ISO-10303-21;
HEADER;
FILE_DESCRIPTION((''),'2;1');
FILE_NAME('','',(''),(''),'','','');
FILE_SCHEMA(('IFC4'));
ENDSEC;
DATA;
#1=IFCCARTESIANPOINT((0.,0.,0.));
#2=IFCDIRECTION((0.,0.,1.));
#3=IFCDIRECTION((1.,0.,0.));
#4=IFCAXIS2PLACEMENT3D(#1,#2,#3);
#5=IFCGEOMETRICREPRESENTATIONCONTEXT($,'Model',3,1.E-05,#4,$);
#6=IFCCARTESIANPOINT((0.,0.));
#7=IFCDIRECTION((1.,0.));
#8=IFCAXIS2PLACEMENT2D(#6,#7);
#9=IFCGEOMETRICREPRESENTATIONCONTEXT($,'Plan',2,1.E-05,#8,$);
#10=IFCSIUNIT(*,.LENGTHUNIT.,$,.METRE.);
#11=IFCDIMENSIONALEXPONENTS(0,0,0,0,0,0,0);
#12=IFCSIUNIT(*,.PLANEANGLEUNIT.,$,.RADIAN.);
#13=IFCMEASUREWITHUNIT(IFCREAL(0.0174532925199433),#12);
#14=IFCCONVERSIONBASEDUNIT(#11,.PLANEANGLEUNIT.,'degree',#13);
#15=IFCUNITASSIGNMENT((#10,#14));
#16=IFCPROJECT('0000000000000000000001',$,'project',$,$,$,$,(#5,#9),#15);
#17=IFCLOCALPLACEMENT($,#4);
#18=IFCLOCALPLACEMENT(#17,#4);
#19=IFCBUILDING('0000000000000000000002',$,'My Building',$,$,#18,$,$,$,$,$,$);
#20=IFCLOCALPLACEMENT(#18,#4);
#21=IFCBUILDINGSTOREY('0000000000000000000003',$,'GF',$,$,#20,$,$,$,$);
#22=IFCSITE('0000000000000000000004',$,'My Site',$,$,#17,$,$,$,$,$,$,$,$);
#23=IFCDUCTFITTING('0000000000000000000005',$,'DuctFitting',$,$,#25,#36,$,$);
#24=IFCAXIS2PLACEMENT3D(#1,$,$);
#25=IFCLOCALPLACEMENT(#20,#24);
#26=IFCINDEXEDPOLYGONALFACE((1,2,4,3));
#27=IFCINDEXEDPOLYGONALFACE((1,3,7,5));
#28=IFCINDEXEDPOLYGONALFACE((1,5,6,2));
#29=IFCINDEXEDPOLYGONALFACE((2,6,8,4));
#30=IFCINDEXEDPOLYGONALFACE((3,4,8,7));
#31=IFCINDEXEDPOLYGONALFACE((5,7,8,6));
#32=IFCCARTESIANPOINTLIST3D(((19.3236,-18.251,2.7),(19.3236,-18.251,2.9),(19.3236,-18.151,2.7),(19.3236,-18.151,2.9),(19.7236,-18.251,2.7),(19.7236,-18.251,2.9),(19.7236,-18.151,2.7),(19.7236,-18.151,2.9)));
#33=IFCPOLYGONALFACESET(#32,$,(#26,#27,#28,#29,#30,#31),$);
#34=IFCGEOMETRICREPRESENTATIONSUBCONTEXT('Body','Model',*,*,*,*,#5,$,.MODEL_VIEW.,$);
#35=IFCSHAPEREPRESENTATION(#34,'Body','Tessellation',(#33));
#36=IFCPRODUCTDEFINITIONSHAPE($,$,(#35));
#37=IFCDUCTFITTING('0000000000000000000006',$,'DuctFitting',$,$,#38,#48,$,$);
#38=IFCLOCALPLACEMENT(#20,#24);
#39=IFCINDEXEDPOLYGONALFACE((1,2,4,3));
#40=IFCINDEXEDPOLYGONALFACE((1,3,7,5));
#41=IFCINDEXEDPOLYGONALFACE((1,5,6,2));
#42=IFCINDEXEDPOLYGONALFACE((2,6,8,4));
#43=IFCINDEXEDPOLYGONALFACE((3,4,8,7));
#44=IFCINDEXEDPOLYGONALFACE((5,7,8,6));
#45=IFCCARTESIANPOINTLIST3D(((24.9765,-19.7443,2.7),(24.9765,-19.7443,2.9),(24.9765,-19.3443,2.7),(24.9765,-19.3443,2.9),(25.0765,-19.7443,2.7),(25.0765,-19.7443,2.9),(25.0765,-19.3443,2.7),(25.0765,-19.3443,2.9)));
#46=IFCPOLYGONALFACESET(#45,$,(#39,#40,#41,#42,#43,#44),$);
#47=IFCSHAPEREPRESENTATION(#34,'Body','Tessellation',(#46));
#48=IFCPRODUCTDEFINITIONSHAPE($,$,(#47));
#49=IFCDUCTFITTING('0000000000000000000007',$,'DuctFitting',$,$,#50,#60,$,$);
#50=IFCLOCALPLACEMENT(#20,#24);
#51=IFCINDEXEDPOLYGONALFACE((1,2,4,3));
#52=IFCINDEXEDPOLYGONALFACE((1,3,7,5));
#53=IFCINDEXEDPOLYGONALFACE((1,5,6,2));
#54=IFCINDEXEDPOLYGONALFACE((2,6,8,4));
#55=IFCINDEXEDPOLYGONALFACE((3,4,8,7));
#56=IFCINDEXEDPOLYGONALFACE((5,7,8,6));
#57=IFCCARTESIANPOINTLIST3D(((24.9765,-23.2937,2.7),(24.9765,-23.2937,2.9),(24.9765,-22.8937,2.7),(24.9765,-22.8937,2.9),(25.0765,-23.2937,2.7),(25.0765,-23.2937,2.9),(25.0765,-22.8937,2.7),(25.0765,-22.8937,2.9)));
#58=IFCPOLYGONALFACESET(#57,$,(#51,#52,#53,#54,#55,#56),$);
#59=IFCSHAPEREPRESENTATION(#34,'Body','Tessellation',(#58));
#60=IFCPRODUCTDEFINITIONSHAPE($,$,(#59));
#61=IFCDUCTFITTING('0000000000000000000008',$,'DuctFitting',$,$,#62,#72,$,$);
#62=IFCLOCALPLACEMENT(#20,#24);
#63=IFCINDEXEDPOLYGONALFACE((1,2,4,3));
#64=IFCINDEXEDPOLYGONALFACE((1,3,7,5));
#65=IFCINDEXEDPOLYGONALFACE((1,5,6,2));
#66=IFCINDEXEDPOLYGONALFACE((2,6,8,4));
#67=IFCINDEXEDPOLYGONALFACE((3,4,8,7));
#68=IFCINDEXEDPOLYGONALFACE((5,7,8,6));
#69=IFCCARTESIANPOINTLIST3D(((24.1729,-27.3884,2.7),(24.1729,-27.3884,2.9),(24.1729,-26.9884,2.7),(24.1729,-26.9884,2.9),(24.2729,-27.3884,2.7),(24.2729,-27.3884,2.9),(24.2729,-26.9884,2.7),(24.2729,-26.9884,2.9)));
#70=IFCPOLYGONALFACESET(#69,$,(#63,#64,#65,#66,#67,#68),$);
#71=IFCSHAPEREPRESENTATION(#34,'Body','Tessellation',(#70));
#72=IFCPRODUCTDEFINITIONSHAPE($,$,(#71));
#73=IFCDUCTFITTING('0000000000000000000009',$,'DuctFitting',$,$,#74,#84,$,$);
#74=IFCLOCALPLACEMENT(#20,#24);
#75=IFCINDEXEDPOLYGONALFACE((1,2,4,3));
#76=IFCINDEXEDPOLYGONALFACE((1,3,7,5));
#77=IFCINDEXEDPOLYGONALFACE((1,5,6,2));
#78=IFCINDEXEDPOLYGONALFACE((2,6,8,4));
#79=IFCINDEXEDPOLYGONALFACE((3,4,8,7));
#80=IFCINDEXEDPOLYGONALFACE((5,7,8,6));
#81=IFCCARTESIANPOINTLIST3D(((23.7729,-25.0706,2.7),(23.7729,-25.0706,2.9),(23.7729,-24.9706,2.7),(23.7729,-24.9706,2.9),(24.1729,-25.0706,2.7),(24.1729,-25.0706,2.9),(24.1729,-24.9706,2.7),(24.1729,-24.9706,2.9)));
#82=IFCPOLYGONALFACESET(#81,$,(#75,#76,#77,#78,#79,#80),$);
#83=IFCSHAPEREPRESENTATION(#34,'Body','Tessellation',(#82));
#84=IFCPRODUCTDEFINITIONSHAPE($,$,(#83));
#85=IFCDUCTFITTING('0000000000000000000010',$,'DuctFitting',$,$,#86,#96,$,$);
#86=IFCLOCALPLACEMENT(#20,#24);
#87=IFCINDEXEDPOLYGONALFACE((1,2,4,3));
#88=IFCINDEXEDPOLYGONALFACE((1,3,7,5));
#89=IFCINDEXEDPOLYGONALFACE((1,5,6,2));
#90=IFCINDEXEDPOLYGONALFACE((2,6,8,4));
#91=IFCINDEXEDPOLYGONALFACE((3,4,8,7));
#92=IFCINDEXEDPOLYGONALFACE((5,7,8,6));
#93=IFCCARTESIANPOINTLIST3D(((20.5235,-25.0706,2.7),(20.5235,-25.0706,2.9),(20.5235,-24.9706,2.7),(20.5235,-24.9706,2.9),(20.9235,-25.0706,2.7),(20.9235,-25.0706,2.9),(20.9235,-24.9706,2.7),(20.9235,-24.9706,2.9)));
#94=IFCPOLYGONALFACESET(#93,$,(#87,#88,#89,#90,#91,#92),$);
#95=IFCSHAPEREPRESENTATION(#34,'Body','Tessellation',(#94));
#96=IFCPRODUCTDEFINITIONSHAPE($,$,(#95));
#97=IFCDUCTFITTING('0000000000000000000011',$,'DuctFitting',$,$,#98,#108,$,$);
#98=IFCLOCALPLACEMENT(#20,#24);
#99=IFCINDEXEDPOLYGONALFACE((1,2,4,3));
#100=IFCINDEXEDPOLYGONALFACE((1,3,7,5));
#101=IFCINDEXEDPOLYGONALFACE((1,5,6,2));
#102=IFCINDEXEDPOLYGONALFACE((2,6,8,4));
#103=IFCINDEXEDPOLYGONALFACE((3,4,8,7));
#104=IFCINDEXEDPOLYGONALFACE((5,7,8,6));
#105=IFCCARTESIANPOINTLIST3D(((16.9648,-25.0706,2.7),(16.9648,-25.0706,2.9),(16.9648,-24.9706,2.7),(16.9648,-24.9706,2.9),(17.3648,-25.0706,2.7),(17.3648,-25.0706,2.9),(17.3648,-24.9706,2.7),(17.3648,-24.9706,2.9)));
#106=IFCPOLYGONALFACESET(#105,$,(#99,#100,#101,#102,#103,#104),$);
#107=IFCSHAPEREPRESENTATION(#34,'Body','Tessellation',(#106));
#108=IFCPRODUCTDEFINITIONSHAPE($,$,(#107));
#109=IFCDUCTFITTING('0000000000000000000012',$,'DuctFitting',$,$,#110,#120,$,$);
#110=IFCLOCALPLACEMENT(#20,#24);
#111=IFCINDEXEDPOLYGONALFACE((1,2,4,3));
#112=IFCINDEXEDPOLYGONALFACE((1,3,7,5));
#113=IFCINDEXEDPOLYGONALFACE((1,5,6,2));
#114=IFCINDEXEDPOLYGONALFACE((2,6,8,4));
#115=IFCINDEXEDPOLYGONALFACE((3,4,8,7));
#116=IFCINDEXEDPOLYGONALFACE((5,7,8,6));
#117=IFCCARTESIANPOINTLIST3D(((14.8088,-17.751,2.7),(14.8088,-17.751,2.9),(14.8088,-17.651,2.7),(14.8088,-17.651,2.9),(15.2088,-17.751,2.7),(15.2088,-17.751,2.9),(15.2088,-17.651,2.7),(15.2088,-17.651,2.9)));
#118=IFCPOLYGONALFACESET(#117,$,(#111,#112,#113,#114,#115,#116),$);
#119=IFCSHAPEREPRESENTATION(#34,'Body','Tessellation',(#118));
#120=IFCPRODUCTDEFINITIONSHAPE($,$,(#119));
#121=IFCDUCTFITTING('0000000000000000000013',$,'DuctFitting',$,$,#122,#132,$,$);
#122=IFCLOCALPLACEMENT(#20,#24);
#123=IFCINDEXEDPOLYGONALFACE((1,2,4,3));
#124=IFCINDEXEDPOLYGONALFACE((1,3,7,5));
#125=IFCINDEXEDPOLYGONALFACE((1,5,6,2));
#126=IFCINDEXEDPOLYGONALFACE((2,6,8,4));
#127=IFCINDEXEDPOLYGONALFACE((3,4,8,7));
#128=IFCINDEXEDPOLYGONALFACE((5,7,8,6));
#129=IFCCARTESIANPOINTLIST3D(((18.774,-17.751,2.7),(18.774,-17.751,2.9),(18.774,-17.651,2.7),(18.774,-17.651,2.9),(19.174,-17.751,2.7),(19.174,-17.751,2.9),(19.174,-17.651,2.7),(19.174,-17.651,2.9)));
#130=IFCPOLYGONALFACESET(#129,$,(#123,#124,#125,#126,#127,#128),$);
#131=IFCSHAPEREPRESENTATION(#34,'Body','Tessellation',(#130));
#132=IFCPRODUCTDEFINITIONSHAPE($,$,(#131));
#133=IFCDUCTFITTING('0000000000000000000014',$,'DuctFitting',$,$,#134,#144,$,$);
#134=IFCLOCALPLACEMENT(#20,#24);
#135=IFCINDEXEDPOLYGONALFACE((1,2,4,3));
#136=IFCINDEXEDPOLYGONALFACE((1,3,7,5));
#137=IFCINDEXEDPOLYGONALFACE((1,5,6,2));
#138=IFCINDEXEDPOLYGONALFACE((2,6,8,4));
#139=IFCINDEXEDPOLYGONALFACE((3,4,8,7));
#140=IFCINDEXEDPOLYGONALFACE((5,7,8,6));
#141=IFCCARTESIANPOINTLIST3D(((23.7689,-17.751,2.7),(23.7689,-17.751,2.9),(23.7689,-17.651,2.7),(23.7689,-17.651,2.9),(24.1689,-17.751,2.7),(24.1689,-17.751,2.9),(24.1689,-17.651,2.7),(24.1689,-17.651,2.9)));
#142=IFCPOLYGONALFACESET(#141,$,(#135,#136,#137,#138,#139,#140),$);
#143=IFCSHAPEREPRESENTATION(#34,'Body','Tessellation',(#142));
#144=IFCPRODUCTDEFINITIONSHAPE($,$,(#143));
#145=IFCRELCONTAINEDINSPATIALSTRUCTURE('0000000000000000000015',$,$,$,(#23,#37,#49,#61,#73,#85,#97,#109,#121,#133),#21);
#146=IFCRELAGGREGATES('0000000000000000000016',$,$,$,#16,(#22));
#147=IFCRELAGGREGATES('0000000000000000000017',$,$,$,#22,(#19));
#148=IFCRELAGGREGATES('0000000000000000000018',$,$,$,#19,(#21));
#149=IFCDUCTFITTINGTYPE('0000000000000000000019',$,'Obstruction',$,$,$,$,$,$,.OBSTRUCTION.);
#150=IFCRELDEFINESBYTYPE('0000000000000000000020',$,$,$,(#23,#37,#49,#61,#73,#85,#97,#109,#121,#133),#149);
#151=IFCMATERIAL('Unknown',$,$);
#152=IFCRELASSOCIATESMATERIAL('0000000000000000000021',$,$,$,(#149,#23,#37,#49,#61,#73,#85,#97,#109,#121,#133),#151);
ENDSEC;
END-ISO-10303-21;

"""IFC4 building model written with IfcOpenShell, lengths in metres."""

from ifc_helpers import new_model, entity, si_unit, converted_unit, frame, origin_with_axes, origin_2d_with_axis, place, context, subcontext, project, spatial, rectangle, extrude, material, material_profile, profile_set, profile_usage, type_object, element, save


model = new_model("IFC4")

# Units and contexts
model_context = context("Model", 3, precision=1e-05, world=origin_with_axes())
plan_context = context("Plan", 2, precision=1e-05, world=origin_2d_with_axis())
body_context_1 = subcontext(model_context, "Body", "Model", "MODEL_VIEW")
ifc_project = project(units=[si_unit("LENGTHUNIT", "METRE"), converted_unit("PLANEANGLEUNIT", "degree", entity("IfcReal", 0.0174532925199433), si_unit("PLANEANGLEUNIT", "RADIAN"), dimensions=[0, 0, 0, 0, 0, 0, 0])], contexts=[model_context, plan_context])

# Site, building, storey
site_placement = place(None, origin_with_axes())
site = spatial("IfcSite", under=ifc_project, at=site_placement, Name="My Site")
building_placement = place(site_placement, origin_with_axes())
building = spatial("IfcBuilding", under=site, at=building_placement, Name="My Building")
storey_placement = place(building_placement, origin_with_axes())
storey = spatial("IfcBuildingStorey", under=building, at=storey_placement, Name="GF")

# Shared definitions
ifc_material = material(Name="Unknown")

# Duct fittings
ifc_material_profile = material_profile(ifc_material, rectangle(XDim=0.4, YDim=0.2))
ifc_profile_set = profile_set([ifc_material_profile])
duct_fitting_type = type_object("IfcDuctFittingType", Name="Obstruction", PredefinedType="OBSTRUCTION", material=ifc_profile_set)
ifc_profile_usage_1 = profile_usage(ifc_profile_set, cardinal=5)
duct_fitting_1_placement = place(storey_placement, frame((19.5236, -18.251, 2.8), z_axis=(0.0, 1.0, 0.0), x_axis=(-1.0, 0.0, 0.0)))
element("IfcDuctFitting", 1, at=duct_fitting_1_placement, inside=storey, type_object=duct_fitting_type, material=ifc_profile_usage_1, Name="DuctFitting", context=body_context_1, shape_type="SweptSolid", body=[
    extrude(rectangle(XDim=0.4, YDim=0.2), origin_with_axes(), (0.0, 0.0, 1.0), 0.1),
])
ifc_profile_usage_2 = profile_usage(ifc_profile_set, cardinal=5)
duct_fitting_2_placement = place(storey_placement, frame((25.0765, -19.5443, 2.8), z_axis=(-1.0, 0.0, 0.0), x_axis=(0.0, -1.0, 0.0)))
element("IfcDuctFitting", 2, at=duct_fitting_2_placement, inside=storey, type_object=duct_fitting_type, material=ifc_profile_usage_2, Name="DuctFitting", context=body_context_1, shape_type="SweptSolid", body=[
    extrude(rectangle(XDim=0.4, YDim=0.2), origin_with_axes(), (0.0, 0.0, 1.0), 0.1),
])
ifc_profile_usage_3 = profile_usage(ifc_profile_set, cardinal=5)
duct_fitting_3_placement = place(storey_placement, frame((25.0765, -23.0937, 2.8), z_axis=(-1.0, 0.0, 0.0), x_axis=(0.0, -1.0, 0.0)))
element("IfcDuctFitting", 3, at=duct_fitting_3_placement, inside=storey, type_object=duct_fitting_type, material=ifc_profile_usage_3, Name="DuctFitting", context=body_context_1, shape_type="SweptSolid", body=[
    extrude(rectangle(XDim=0.4, YDim=0.2), origin_with_axes(), (0.0, 0.0, 1.0), 0.1),
])
ifc_profile_usage_4 = profile_usage(ifc_profile_set, cardinal=5)
duct_fitting_4_placement = place(storey_placement, frame((24.2729, -27.1884, 2.8), z_axis=(-1.0, 0.0, 0.0), x_axis=(0.0, -1.0, 0.0)))
element("IfcDuctFitting", 4, at=duct_fitting_4_placement, inside=storey, type_object=duct_fitting_type, material=ifc_profile_usage_4, Name="DuctFitting", context=body_context_1, shape_type="SweptSolid", body=[
    extrude(rectangle(XDim=0.4, YDim=0.2), origin_with_axes(), (0.0, 0.0, 1.0), 0.1),
])
ifc_profile_usage_5 = profile_usage(ifc_profile_set, cardinal=5)
duct_fitting_5_placement = place(storey_placement, frame((23.9729, -25.0706, 2.8), z_axis=(0.0, 1.0, 0.0), x_axis=(-1.0, 0.0, 0.0)))
element("IfcDuctFitting", 5, at=duct_fitting_5_placement, inside=storey, type_object=duct_fitting_type, material=ifc_profile_usage_5, Name="DuctFitting", context=body_context_1, shape_type="SweptSolid", body=[
    extrude(rectangle(XDim=0.4, YDim=0.2), origin_with_axes(), (0.0, 0.0, 1.0), 0.1),
])
ifc_profile_usage_6 = profile_usage(ifc_profile_set, cardinal=5)
duct_fitting_6_placement = place(storey_placement, frame((20.7235, -25.0706, 2.8), z_axis=(0.0, 1.0, 0.0), x_axis=(-1.0, 0.0, 0.0)))
element("IfcDuctFitting", 6, at=duct_fitting_6_placement, inside=storey, type_object=duct_fitting_type, material=ifc_profile_usage_6, Name="DuctFitting", context=body_context_1, shape_type="SweptSolid", body=[
    extrude(rectangle(XDim=0.4, YDim=0.2), origin_with_axes(), (0.0, 0.0, 1.0), 0.1),
])
ifc_profile_usage_7 = profile_usage(ifc_profile_set, cardinal=5)
duct_fitting_7_placement = place(storey_placement, frame((17.1648, -25.0706, 2.8), z_axis=(0.0, 1.0, 0.0), x_axis=(-1.0, 0.0, 0.0)))
element("IfcDuctFitting", 7, at=duct_fitting_7_placement, inside=storey, type_object=duct_fitting_type, material=ifc_profile_usage_7, Name="DuctFitting", context=body_context_1, shape_type="SweptSolid", body=[
    extrude(rectangle(XDim=0.4, YDim=0.2), origin_with_axes(), (0.0, 0.0, 1.0), 0.1),
])
ifc_profile_usage_8 = profile_usage(ifc_profile_set, cardinal=5)
duct_fitting_8_placement = place(storey_placement, frame((15.0088, -17.651, 2.8), z_axis=(0.0, -1.0, 0.0), x_axis=(1.0, 0.0, 0.0)))
element("IfcDuctFitting", 8, at=duct_fitting_8_placement, inside=storey, type_object=duct_fitting_type, material=ifc_profile_usage_8, Name="DuctFitting", context=body_context_1, shape_type="SweptSolid", body=[
    extrude(rectangle(XDim=0.4, YDim=0.2), origin_with_axes(), (0.0, 0.0, 1.0), 0.1),
])
ifc_profile_usage_9 = profile_usage(ifc_profile_set, cardinal=5)
duct_fitting_9_placement = place(storey_placement, frame((18.974, -17.651, 2.8), z_axis=(0.0, -1.0, 0.0), x_axis=(1.0, 0.0, 0.0)))
element("IfcDuctFitting", 9, at=duct_fitting_9_placement, inside=storey, type_object=duct_fitting_type, material=ifc_profile_usage_9, Name="DuctFitting", context=body_context_1, shape_type="SweptSolid", body=[
    extrude(rectangle(XDim=0.4, YDim=0.2), origin_with_axes(), (0.0, 0.0, 1.0), 0.1),
])
ifc_profile_usage_10 = profile_usage(ifc_profile_set, cardinal=5)
duct_fitting_10_placement = place(storey_placement, frame((23.9689, -17.651, 2.8), z_axis=(0.0, -1.0, 0.0), x_axis=(1.0, 0.0, 0.0)))
element("IfcDuctFitting", 10, at=duct_fitting_10_placement, inside=storey, type_object=duct_fitting_type, material=ifc_profile_usage_10, Name="DuctFitting", context=body_context_1, shape_type="SweptSolid", body=[
    extrude(rectangle(XDim=0.4, YDim=0.2), origin_with_axes(), (0.0, 0.0, 1.0), 0.1),
])

save(model, "model.ifc")
